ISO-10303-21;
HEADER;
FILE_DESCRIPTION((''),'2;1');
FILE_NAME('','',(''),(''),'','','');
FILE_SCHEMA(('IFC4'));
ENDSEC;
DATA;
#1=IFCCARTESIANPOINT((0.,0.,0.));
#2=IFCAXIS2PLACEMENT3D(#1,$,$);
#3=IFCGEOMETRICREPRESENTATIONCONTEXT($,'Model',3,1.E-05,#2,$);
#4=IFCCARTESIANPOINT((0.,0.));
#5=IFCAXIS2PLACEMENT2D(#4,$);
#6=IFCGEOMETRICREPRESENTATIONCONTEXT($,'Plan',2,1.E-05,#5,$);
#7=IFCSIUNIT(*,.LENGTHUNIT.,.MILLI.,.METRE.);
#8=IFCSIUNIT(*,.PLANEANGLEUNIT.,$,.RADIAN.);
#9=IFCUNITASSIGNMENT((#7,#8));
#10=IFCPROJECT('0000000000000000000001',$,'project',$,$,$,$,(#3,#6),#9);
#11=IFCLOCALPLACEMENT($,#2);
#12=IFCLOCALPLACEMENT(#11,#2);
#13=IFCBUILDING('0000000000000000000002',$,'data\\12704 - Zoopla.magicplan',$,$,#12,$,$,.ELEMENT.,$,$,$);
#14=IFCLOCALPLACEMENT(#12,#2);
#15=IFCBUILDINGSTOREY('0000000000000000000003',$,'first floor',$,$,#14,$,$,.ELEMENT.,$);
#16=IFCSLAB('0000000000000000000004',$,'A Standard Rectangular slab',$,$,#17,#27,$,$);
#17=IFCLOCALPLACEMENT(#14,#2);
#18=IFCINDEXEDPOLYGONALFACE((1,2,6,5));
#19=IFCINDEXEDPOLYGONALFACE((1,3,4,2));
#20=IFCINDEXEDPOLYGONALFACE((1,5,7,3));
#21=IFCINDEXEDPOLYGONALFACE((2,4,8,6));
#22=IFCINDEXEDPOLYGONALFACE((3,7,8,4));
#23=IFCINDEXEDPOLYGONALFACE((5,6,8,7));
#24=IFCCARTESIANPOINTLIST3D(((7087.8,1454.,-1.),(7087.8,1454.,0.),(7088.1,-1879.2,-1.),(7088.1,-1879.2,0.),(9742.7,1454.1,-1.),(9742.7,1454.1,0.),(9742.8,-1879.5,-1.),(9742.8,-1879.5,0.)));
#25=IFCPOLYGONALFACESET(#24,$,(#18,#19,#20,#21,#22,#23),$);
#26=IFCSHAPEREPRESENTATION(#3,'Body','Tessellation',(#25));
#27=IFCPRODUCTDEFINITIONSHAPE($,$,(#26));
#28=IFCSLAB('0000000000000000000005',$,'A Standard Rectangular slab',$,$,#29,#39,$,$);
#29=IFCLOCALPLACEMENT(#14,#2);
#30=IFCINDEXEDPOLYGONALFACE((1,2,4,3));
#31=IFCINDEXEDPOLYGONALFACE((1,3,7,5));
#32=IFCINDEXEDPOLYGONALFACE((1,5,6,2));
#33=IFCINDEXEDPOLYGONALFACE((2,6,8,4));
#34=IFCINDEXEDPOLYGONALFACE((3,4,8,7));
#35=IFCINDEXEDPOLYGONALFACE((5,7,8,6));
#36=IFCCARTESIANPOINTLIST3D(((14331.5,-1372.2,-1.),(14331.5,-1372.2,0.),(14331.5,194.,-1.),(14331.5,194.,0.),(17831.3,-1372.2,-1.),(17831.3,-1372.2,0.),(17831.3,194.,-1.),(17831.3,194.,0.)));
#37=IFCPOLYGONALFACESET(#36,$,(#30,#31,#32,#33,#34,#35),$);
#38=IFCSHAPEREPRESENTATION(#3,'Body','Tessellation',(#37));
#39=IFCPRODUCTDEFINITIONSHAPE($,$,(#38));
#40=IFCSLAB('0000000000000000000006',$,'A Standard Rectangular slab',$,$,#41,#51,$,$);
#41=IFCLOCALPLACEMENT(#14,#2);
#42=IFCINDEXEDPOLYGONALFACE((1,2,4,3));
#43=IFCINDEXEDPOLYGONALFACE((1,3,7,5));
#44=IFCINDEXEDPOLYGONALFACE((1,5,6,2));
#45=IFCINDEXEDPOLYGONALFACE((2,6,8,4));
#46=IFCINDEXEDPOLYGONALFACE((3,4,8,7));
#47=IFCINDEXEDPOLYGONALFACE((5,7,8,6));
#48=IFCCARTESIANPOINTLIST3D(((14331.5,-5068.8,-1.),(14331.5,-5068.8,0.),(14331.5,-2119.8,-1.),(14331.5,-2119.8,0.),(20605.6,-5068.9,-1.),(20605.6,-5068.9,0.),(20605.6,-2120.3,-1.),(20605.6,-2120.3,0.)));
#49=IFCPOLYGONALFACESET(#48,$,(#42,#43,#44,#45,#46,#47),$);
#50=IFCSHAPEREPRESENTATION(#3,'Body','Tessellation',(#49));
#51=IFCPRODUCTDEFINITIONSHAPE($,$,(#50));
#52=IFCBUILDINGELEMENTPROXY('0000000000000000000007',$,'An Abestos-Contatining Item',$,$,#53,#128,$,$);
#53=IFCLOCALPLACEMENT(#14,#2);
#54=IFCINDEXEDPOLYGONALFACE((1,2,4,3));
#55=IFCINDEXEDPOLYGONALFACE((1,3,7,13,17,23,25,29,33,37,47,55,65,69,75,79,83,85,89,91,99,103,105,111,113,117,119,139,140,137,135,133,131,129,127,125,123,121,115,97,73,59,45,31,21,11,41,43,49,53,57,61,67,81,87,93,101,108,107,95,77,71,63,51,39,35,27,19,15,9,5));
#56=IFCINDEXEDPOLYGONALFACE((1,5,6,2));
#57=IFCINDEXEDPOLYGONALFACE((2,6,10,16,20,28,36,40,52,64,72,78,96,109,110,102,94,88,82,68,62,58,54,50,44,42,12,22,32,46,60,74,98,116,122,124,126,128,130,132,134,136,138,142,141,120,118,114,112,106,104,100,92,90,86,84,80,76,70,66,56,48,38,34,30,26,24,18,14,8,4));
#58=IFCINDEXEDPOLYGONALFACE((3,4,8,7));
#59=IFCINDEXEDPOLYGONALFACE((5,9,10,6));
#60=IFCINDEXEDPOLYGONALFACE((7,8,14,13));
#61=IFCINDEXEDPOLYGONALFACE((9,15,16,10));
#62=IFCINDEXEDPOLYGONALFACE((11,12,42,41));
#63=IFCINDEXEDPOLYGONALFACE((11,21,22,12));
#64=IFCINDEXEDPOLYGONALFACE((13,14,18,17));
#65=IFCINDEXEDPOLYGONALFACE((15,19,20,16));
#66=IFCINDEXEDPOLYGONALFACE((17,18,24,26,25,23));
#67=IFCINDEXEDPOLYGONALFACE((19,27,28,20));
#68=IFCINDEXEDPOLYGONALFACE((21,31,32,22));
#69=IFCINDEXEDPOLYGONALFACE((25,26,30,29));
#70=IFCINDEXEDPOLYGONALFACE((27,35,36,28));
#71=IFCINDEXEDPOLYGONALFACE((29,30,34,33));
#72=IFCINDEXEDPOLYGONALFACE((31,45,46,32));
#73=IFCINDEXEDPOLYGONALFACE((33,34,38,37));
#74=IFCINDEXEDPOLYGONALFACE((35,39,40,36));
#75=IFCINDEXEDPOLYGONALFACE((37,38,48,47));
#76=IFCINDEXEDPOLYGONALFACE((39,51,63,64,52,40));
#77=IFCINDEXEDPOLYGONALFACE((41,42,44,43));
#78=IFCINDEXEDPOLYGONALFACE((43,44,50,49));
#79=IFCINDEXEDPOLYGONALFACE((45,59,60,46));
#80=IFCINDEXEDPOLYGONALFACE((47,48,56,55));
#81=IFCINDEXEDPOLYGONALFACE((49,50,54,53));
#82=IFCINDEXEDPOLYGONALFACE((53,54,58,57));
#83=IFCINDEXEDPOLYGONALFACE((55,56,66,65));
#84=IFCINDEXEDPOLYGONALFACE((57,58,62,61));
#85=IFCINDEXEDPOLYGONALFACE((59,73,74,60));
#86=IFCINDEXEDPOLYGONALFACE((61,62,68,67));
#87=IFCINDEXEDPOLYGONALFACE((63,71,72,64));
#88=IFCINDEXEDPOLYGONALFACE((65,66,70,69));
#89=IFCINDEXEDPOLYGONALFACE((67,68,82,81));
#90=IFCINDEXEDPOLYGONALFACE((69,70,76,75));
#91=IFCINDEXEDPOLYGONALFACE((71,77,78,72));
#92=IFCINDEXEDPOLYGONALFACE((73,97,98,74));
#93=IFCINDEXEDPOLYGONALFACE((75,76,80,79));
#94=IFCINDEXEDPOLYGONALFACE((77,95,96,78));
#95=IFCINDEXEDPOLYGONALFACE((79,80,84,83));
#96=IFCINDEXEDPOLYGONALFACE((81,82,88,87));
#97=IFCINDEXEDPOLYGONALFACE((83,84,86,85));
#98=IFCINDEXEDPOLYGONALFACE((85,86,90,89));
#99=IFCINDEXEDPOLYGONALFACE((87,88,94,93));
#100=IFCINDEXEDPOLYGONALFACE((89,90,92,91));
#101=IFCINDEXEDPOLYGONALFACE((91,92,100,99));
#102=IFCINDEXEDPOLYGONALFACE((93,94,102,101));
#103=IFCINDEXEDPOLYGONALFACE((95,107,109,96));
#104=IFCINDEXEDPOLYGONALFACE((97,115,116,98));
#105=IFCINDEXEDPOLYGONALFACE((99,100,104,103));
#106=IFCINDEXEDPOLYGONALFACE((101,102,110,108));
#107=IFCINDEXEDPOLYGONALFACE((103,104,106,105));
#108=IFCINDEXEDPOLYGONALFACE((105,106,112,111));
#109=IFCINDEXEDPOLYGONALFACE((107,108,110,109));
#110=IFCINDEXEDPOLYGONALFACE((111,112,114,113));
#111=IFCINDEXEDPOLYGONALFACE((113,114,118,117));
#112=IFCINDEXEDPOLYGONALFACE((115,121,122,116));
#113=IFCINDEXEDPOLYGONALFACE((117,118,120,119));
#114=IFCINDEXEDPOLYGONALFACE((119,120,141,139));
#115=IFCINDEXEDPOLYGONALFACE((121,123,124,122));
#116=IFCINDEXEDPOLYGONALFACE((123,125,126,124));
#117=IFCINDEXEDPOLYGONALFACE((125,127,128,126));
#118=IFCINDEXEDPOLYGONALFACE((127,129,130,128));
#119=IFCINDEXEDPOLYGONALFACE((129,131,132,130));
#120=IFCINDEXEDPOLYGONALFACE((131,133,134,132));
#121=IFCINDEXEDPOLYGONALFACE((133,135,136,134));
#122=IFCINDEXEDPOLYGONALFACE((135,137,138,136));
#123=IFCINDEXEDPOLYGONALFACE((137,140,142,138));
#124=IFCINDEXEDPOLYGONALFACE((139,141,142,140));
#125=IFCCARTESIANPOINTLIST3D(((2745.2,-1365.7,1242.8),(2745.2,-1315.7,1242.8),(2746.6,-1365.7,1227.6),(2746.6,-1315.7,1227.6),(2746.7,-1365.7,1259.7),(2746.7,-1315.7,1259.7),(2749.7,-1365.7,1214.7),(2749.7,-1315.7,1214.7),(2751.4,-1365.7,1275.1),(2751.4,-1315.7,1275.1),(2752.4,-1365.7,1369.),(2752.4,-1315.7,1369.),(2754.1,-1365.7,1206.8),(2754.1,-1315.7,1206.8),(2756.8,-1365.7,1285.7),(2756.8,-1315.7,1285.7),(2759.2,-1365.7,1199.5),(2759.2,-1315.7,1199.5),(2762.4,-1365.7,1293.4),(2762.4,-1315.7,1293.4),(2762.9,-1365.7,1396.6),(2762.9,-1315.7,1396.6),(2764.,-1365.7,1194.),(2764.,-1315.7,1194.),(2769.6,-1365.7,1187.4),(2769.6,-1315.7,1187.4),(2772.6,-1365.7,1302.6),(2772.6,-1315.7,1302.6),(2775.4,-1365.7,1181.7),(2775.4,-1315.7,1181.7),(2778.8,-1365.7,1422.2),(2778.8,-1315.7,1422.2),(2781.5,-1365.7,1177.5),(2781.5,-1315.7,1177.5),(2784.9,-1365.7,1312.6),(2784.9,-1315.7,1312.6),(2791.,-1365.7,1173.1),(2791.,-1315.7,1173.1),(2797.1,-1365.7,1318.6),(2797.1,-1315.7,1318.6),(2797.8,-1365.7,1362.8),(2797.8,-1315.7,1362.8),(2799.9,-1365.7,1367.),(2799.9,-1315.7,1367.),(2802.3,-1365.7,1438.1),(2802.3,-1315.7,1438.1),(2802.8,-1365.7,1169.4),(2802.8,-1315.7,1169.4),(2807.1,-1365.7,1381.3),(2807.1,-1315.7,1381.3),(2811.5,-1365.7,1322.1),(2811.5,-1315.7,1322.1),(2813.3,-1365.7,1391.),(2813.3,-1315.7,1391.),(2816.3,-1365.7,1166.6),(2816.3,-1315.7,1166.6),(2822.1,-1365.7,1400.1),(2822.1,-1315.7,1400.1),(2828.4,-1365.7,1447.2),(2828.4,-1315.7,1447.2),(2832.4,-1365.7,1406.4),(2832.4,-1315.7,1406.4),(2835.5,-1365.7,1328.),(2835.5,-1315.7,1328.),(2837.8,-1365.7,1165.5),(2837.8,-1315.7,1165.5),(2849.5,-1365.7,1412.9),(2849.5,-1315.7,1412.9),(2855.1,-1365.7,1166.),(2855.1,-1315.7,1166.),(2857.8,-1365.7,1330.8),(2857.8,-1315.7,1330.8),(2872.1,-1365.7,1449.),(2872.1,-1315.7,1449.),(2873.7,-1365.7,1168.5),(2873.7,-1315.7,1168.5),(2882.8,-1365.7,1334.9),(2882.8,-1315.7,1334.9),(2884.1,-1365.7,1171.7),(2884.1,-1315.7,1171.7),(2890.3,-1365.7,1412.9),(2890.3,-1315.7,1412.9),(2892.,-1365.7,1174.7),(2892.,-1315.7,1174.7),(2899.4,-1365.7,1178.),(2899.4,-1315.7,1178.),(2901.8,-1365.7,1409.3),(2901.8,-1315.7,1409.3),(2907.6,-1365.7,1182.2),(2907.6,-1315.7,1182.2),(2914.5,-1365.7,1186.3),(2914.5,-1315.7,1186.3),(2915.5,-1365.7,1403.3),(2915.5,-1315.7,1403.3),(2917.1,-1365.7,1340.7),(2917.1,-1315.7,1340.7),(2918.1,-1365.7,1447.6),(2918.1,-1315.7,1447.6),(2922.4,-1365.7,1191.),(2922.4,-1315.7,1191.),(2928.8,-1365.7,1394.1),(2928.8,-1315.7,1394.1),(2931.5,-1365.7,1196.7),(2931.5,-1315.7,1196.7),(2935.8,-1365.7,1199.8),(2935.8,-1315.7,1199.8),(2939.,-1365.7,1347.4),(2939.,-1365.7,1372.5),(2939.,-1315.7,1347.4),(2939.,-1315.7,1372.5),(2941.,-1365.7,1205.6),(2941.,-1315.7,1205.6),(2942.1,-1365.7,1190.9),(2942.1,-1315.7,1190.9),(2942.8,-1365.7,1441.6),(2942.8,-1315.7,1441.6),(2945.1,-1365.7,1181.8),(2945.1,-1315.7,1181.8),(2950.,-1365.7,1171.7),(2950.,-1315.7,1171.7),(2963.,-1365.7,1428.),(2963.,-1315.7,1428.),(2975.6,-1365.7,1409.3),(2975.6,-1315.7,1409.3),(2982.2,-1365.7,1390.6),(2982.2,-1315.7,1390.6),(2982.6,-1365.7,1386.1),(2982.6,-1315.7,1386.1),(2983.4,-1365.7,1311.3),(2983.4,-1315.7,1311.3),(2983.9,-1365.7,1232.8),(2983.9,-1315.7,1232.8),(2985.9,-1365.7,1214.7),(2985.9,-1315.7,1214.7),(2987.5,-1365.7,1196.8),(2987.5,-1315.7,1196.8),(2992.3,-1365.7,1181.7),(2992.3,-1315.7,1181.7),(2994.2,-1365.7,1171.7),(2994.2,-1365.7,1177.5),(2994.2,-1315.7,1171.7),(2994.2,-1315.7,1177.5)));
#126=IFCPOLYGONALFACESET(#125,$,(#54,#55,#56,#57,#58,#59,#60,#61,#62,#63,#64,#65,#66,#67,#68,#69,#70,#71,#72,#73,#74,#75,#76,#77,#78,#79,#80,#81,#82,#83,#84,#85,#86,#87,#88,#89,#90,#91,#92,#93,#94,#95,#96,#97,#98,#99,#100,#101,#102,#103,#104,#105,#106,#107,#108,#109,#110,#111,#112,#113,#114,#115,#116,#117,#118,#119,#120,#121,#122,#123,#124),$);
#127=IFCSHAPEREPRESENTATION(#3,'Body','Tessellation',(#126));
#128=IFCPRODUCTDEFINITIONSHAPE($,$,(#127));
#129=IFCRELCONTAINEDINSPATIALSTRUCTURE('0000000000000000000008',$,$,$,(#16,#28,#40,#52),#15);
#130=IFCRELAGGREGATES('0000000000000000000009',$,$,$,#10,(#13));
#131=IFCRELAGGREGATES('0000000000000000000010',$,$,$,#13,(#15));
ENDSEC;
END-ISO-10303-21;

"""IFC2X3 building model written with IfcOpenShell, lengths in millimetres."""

from ifc_helpers import new_model, si_unit, frame, origin, origin_2d, place, context, project, spatial, polyline, outline, extrude, element, save


model = new_model("IFC2X3")

# Units and contexts
model_context = context("Model", 3, precision=1e-05, world=origin())
plan_context = context("Plan", 2, precision=1e-05, world=origin_2d())
ifc_project = project(units=[si_unit("LENGTHUNIT", "METRE", prefix="MILLI"), si_unit("PLANEANGLEUNIT", "RADIAN")], contexts=[model_context, plan_context])

# Building, storey
placement_1 = place(None, origin())
building_placement = place(placement_1, origin())
building = spatial("IfcBuilding", under=ifc_project, at=building_placement, Name="data\\12704 - Zoopla.magicplan", CompositionType="ELEMENT")
storey_placement = place(building_placement, origin())
storey = spatial("IfcBuildingStorey", under=building, at=storey_placement, Name="first floor", CompositionType="ELEMENT")

# Slabs
placement_2 = place(None, frame((8415.3, -212.7, 0.0)))
slab_1_placement = place(placement_2, origin())
element("IfcSlab", 1, at=slab_1_placement, inside=storey, Name="A Standard Rectangular slab", context=model_context, shape_type="SweptSolid", body=[
    extrude(outline(polyline([(-1327.2, -1666.5, 0.0), (-1327.5, 1666.7, 0.0), (1327.4, 1666.8, 0.0), (1327.5, -1666.8, 0.0), (-1327.2, -1666.5, 0.0)]), kind="CURVE"), origin(), (0.0, 0.0, -1.0), 1.0),
])
placement_3 = place(None, frame((16081.4, -589.1, 0.0)))
slab_2_placement = place(placement_3, origin())
element("IfcSlab", 2, at=slab_2_placement, inside=storey, Name="A Standard Rectangular slab", context=model_context, shape_type="SweptSolid", body=[
    extrude(outline(polyline([(1749.9, -783.1, 0.0), (-1749.9, -783.1, 0.0), (-1749.9, 783.1, 0.0), (1749.9, 783.1, 0.0), (1749.9, -783.1, 0.0)]), kind="CURVE"), origin(), (0.0, 0.0, -1.0), 1.0),
])
placement_4 = place(None, frame((17468.6, -3594.3, 0.0)))
slab_3_placement = place(placement_4, origin())
element("IfcSlab", 3, at=slab_3_placement, inside=storey, Name="A Standard Rectangular slab", context=model_context, shape_type="SweptSolid", body=[
    extrude(outline(polyline([(3137.1, 1474.1, 0.0), (3137.1, -1474.5, 0.0), (-3137.1, -1474.5, 0.0), (-3137.1, 1474.5, 0.0), (3137.1, 1474.1, 0.0)]), kind="CURVE"), origin(), (0.0, 0.0, -1.0), 1.0),
])

# Building element proxy
placement_5 = place(None, frame((3984.0, 1316.8, 0.0)))
proxy_1_placement = place(placement_5, frame((-1239.8, -2632.4, 1165.0)))
element("IfcBuildingElementProxy", 4, at=proxy_1_placement, inside=storey, Name="An Abestos-Contatining Item", context=model_context, shape_type="SurfaceModel", body=[
    extrude(outline(polyline([(239.2, 0.0, 146.3), (239.7, 0.0, 67.8), (241.8, 0.0, 49.7), (243.3, 0.0, 31.9), (248.1, 0.0, 16.7), (250.0, 0.0, 12.5), (250.0, 0.0, 6.7), (205.8, 0.0, 6.7), (200.9, 0.0, 16.8), (197.9, 0.0, 25.9), (196.9, 0.0, 40.6), (191.6, 0.0, 34.8), (187.3, 0.0, 31.7), (178.2, 0.0, 26.0), (170.3, 0.0, 21.3), (163.4, 0.0, 17.2), (155.2, 0.0, 13.0), (147.8, 0.0, 9.7), (139.9, 0.0, 6.7), (129.5, 0.0, 3.5), (110.9, 0.0, 1.0), (93.6, 0.0, 0.5), (72.1, 0.0, 1.6), (58.6, 0.0, 4.4), (46.9, 0.0, 8.1), (37.3, 0.0, 12.5), (31.2, 0.0, 16.7), (25.4, 0.0, 22.4), (19.8, 0.0, 29.0), (15.1, 0.0, 34.5), (9.9, 0.0, 41.9), (5.5, 0.0, 49.7), (2.5, 0.0, 62.6), (1.0, 0.0, 77.8), (2.5, 0.0, 94.7), (7.2, 0.0, 110.1), (12.6, 0.0, 120.7), (18.2, 0.0, 128.4), (28.4, 0.0, 137.6), (40.7, 0.0, 147.6), (52.9, 0.0, 153.6), (67.3, 0.0, 157.1), (91.3, 0.0, 163.0), (113.7, 0.0, 165.8), (138.6, 0.0, 169.9), (172.9, 0.0, 175.7), (194.8, 0.0, 182.4), (194.8, 0.0, 207.5), (184.7, 0.0, 229.1), (171.3, 0.0, 238.3), (157.6, 0.0, 244.3), (146.2, 0.0, 247.9), (105.3, 0.0, 247.9), (88.3, 0.0, 241.4), (77.9, 0.0, 235.1), (69.1, 0.0, 226.0), (62.9, 0.0, 216.3), (55.7, 0.0, 202.0), (53.6, 0.0, 197.8), (8.2, 0.0, 204.0), (18.7, 0.0, 231.7), (34.6, 0.0, 257.2), (58.1, 0.0, 273.1), (84.2, 0.0, 282.2), (128.0, 0.0, 284.0), (173.9, 0.0, 282.6), (198.6, 0.0, 276.6), (218.8, 0.0, 263.1), (231.4, 0.0, 244.3), (238.0, 0.0, 225.6), (238.5, 0.0, 221.1)]), holes=[polyline([(193.0, 0.0, 144.2), (193.0, 0.0, 117.7), (190.5, 0.0, 97.8), (183.8, 0.0, 80.4), (174.2, 0.0, 64.5), (165.3, 0.0, 54.4), (152.5, 0.0, 47.3), (138.0, 0.0, 41.5), (124.6, 0.0, 37.8), (85.5, 0.0, 37.8), (75.0, 0.0, 41.4), (65.8, 0.0, 47.1), (57.8, 0.0, 55.4), (52.1, 0.0, 66.4), (49.5, 0.0, 74.4), (49.5, 0.0, 88.6), (55.3, 0.0, 100.7), (65.3, 0.0, 109.9), (81.0, 0.0, 119.8), (101.0, 0.0, 125.3), (119.9, 0.0, 128.5), (146.8, 0.0, 131.5), (165.0, 0.0, 134.9), (179.8, 0.0, 140.1), (193.0, 0.0, 144.2)])], kind="CURVE"), origin(), (0.0, -1.0, 0.0), 50.0),
])

save(model, "model.ifc")
